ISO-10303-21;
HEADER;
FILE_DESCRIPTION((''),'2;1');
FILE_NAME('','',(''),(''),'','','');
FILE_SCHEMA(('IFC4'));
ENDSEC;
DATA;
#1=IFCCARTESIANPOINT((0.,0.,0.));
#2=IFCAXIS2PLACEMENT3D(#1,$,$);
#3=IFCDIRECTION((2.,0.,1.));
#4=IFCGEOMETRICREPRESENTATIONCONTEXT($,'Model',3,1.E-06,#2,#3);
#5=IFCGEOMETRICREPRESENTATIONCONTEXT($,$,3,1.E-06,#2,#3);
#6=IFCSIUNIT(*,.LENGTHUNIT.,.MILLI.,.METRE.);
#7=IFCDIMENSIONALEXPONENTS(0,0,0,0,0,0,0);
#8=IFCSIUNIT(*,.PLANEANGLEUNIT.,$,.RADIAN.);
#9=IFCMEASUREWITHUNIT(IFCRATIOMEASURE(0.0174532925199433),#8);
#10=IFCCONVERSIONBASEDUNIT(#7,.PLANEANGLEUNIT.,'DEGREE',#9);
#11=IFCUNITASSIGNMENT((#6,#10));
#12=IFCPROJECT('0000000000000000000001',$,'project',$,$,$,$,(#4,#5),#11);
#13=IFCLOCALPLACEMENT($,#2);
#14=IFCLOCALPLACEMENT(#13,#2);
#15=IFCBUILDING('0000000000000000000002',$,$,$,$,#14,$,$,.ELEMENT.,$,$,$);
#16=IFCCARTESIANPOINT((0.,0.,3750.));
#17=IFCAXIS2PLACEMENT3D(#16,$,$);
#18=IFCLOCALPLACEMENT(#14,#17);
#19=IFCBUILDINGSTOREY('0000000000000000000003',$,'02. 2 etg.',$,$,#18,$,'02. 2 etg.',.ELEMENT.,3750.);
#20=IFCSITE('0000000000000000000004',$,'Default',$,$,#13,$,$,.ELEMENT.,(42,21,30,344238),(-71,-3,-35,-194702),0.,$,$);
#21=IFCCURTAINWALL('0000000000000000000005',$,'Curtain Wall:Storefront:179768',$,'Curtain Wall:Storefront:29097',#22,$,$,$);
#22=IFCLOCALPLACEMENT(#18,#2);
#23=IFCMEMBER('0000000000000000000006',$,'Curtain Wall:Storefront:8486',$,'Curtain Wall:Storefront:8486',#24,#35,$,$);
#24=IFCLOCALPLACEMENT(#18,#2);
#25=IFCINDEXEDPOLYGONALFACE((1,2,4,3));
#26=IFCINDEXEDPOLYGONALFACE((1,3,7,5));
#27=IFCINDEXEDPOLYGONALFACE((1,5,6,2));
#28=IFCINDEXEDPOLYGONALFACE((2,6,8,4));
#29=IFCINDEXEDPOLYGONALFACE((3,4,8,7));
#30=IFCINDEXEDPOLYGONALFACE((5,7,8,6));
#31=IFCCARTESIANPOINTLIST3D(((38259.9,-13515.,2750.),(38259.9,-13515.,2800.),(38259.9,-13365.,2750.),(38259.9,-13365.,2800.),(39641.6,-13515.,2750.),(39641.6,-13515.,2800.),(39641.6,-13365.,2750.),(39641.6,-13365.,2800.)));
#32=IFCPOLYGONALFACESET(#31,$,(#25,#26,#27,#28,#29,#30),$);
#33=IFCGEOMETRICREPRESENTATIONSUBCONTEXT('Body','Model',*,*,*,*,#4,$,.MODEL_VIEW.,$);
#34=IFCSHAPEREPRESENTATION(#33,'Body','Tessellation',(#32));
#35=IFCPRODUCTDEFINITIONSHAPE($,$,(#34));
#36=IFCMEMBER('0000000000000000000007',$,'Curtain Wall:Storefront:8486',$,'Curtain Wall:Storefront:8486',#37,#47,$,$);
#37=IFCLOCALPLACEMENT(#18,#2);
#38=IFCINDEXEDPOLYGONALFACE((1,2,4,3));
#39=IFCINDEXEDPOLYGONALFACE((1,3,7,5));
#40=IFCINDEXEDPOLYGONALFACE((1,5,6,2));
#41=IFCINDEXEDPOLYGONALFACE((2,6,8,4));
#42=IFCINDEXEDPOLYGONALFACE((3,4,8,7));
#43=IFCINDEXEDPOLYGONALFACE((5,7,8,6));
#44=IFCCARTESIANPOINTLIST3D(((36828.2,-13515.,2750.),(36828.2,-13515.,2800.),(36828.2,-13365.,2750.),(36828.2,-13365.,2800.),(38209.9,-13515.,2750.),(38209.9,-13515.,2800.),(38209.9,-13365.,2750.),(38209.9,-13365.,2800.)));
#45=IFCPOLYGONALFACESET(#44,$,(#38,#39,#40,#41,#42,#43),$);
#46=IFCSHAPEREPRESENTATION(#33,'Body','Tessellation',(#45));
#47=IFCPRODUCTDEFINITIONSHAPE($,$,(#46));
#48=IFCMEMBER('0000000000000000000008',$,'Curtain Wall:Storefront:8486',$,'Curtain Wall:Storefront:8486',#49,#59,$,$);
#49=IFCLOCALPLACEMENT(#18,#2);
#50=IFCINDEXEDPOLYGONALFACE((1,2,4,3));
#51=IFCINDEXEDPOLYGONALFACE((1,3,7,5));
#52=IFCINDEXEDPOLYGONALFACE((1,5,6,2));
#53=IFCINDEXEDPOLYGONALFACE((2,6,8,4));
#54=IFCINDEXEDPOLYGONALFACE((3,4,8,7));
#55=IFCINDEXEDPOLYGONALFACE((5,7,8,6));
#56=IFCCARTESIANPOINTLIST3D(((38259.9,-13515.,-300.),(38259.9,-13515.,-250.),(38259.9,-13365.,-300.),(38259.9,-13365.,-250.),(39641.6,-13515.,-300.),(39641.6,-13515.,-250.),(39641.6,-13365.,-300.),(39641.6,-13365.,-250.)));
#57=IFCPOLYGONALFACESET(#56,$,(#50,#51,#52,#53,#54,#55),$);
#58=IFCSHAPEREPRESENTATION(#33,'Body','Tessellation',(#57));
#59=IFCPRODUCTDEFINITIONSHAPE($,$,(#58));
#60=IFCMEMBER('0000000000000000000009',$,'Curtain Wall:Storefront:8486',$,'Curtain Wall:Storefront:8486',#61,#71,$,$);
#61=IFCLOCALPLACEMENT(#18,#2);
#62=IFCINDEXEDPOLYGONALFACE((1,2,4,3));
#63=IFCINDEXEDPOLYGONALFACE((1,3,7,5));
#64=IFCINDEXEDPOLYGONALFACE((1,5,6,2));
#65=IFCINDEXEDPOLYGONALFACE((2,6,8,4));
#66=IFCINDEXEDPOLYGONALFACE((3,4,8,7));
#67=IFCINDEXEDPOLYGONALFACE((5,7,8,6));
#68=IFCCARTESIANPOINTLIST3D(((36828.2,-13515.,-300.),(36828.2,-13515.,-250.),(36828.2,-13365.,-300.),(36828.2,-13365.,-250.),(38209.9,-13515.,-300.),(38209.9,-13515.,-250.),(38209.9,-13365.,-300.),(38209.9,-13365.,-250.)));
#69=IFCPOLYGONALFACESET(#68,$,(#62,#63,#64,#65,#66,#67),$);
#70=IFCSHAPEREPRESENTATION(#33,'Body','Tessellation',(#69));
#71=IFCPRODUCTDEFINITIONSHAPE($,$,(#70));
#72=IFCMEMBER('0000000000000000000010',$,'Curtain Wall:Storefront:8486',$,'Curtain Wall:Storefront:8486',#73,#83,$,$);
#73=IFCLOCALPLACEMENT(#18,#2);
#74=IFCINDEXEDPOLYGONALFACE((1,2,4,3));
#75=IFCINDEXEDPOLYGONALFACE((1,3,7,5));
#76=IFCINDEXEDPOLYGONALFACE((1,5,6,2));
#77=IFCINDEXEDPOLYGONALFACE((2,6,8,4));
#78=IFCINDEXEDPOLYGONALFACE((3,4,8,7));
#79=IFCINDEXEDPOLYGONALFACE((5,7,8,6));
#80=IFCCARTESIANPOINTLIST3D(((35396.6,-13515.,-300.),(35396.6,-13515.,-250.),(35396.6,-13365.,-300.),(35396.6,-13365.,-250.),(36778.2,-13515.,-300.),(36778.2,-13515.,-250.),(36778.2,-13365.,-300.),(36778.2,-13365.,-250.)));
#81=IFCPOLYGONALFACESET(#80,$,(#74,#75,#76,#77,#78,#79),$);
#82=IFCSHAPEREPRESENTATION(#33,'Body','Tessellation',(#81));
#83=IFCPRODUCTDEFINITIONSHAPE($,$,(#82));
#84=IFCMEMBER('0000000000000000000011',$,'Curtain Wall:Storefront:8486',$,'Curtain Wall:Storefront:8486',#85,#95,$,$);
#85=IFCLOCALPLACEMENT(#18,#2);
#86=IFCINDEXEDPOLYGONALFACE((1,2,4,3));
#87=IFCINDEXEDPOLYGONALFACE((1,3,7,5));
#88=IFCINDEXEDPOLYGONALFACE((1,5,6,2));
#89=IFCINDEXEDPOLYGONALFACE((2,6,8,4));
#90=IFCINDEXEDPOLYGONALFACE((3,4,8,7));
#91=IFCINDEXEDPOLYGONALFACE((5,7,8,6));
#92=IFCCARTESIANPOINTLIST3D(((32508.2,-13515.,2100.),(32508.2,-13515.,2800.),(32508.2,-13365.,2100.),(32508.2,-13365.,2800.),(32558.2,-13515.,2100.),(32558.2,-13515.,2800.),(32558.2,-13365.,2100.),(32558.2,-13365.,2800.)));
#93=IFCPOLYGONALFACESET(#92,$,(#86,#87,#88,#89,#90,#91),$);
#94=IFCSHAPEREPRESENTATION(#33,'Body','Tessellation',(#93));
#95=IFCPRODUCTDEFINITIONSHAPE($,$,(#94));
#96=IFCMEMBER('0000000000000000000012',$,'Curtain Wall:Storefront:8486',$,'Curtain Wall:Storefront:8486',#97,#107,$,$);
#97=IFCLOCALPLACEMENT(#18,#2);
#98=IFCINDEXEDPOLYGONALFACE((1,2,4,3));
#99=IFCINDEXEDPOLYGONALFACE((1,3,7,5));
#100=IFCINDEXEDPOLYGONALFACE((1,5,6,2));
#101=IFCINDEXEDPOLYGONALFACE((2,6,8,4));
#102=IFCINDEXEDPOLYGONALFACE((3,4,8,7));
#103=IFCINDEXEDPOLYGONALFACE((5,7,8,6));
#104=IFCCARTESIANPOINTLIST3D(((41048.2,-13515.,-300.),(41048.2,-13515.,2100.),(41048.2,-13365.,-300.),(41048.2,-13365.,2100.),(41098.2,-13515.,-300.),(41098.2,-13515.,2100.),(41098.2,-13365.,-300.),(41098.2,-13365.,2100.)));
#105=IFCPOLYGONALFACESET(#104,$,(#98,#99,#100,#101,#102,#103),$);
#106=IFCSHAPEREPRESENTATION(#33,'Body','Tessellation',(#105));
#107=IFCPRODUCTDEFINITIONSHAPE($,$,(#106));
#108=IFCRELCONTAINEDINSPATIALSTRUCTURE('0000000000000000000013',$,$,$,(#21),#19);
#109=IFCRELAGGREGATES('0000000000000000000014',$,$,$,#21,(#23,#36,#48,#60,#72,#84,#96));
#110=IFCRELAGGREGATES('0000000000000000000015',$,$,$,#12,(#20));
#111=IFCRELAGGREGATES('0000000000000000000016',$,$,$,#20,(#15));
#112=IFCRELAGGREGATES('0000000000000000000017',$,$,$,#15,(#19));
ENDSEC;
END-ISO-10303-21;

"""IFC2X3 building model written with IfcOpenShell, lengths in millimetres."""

from ifc_helpers import new_model, entity, si_unit, converted_unit, direction, frame, frame_2d, origin, place, context, subcontext, project, spatial, rectangle, extrude, element, aggregate, save


model = new_model("IFC2X3")

# Units and contexts
model_context = context("Model", 3, precision=1e-06, world=origin(), true_north=direction((2.0, 0.0, 1.0)))
context_of_model = context(None, 3, precision=1e-06, world=origin(), true_north=direction((2.0, 0.0, 1.0)))
body_context = subcontext(model_context, "Body", "Model", "MODEL_VIEW")
ifc_project = project(units=[si_unit("LENGTHUNIT", "METRE", prefix="MILLI"), converted_unit("PLANEANGLEUNIT", "DEGREE", entity("IfcRatioMeasure", 0.0174532925199433), si_unit("PLANEANGLEUNIT", "RADIAN"), dimensions=[0, 0, 0, 0, 0, 0, 0])], contexts=[model_context, context_of_model])

# Site, building, storey
site_placement = place(None, origin())
site = spatial("IfcSite", under=ifc_project, at=site_placement, Name="Default", CompositionType="ELEMENT", RefLatitude=(42, 21, 30, 344238), RefLongitude=(-71, -3, -35, -194702), RefElevation=0.0)
building_placement = place(site_placement, origin())
building = spatial("IfcBuilding", under=site, at=building_placement, CompositionType="ELEMENT")
storey_placement = place(building_placement, frame((0.0, 0.0, 3750.0)))
storey = spatial("IfcBuildingStorey", under=building, at=storey_placement, Name="02. 2 etg.", LongName="02. 2 etg.", CompositionType="ELEMENT", Elevation=3750.0)

# Curtain wall, members
curtain_wall_1_placement = place(storey_placement, origin())
curtain_wall_1 = element("IfcCurtainWall", 1, at=curtain_wall_1_placement, inside=storey, Name="Curtain Wall:Storefront:179768", ObjectType="Curtain Wall:Storefront:29097")
member_1_placement = place(storey_placement, origin())
member_1 = element("IfcMember", 2, at=member_1_placement, Name="Curtain Wall:Storefront:8486", ObjectType="Curtain Wall:Storefront:8486", context=body_context, shape_type="SweptSolid", body=[
    extrude(rectangle(XDim=1381.7, YDim=150.0, at=frame_2d((0.0, 0.0), x_axis=(1.0, 0.0))), frame((38950.7, -13440.0, 2750.0)), (0.0, 0.0, 1.0), 50.0),
])
member_2_placement = place(storey_placement, origin())
member_2 = element("IfcMember", 3, at=member_2_placement, Name="Curtain Wall:Storefront:8486", ObjectType="Curtain Wall:Storefront:8486", context=body_context, shape_type="SweptSolid", body=[
    extrude(rectangle(XDim=1381.7, YDim=150.0, at=frame_2d((0.0, 0.0), x_axis=(1.0, 0.0))), frame((37519.1, -13440.0, 2750.0)), (0.0, 0.0, 1.0), 50.0),
])
member_3_placement = place(storey_placement, origin())
member_3 = element("IfcMember", 4, at=member_3_placement, Name="Curtain Wall:Storefront:8486", ObjectType="Curtain Wall:Storefront:8486", context=body_context, shape_type="SweptSolid", body=[
    extrude(rectangle(XDim=1381.7, YDim=150.0, at=frame_2d((0.0, 0.0), x_axis=(1.0, 0.0))), frame((38950.7, -13440.0, -300.0), z_axis=(0.0, 0.0, 1.0), x_axis=(-1.0, 0.0, 0.0)), (0.0, 0.0, 1.0), 50.0),
])
member_4_placement = place(storey_placement, origin())
member_4 = element("IfcMember", 5, at=member_4_placement, Name="Curtain Wall:Storefront:8486", ObjectType="Curtain Wall:Storefront:8486", context=body_context, shape_type="SweptSolid", body=[
    extrude(rectangle(XDim=1381.7, YDim=150.0, at=frame_2d((0.0, 0.0), x_axis=(1.0, 0.0))), frame((37519.1, -13440.0, -300.0), z_axis=(0.0, 0.0, 1.0), x_axis=(-1.0, 0.0, 0.0)), (0.0, 0.0, 1.0), 50.0),
])
member_5_placement = place(storey_placement, origin())
member_5 = element("IfcMember", 6, at=member_5_placement, Name="Curtain Wall:Storefront:8486", ObjectType="Curtain Wall:Storefront:8486", context=body_context, shape_type="SweptSolid", body=[
    extrude(rectangle(XDim=1381.7, YDim=150.0, at=frame_2d((0.0, 0.0), x_axis=(1.0, 0.0))), frame((36087.4, -13440.0, -300.0), z_axis=(0.0, 0.0, 1.0), x_axis=(-1.0, 0.0, 0.0)), (0.0, 0.0, 1.0), 50.0),
])
member_6_placement = place(storey_placement, origin())
member_6 = element("IfcMember", 7, at=member_6_placement, Name="Curtain Wall:Storefront:8486", ObjectType="Curtain Wall:Storefront:8486", context=body_context, shape_type="SweptSolid", body=[
    extrude(rectangle(XDim=150.0, YDim=50.0, at=frame_2d((0.0, 0.0), x_axis=(1.0, 0.0))), frame((32533.2, -13440.0, 2100.0), z_axis=(0.0, 0.0, 1.0), x_axis=(0.0, -1.0, 0.0)), (0.0, 0.0, 1.0), 700.0),
])
member_7_placement = place(storey_placement, origin())
member_7 = element("IfcMember", 8, at=member_7_placement, Name="Curtain Wall:Storefront:8486", ObjectType="Curtain Wall:Storefront:8486", context=body_context, shape_type="SweptSolid", body=[
    extrude(rectangle(XDim=50.0, YDim=150.0, at=frame_2d((0.0, 0.0), x_axis=(1.0, 0.0))), frame((41073.2, -13440.0, -300.0), z_axis=(0.0, 0.0, 1.0), x_axis=(-1.0, 0.0, 0.0)), (0.0, 0.0, 1.0), 2400.0),
])
aggregate(curtain_wall_1, [member_1, member_2, member_3, member_4, member_5, member_6, member_7])

save(model, "model.ifc")
